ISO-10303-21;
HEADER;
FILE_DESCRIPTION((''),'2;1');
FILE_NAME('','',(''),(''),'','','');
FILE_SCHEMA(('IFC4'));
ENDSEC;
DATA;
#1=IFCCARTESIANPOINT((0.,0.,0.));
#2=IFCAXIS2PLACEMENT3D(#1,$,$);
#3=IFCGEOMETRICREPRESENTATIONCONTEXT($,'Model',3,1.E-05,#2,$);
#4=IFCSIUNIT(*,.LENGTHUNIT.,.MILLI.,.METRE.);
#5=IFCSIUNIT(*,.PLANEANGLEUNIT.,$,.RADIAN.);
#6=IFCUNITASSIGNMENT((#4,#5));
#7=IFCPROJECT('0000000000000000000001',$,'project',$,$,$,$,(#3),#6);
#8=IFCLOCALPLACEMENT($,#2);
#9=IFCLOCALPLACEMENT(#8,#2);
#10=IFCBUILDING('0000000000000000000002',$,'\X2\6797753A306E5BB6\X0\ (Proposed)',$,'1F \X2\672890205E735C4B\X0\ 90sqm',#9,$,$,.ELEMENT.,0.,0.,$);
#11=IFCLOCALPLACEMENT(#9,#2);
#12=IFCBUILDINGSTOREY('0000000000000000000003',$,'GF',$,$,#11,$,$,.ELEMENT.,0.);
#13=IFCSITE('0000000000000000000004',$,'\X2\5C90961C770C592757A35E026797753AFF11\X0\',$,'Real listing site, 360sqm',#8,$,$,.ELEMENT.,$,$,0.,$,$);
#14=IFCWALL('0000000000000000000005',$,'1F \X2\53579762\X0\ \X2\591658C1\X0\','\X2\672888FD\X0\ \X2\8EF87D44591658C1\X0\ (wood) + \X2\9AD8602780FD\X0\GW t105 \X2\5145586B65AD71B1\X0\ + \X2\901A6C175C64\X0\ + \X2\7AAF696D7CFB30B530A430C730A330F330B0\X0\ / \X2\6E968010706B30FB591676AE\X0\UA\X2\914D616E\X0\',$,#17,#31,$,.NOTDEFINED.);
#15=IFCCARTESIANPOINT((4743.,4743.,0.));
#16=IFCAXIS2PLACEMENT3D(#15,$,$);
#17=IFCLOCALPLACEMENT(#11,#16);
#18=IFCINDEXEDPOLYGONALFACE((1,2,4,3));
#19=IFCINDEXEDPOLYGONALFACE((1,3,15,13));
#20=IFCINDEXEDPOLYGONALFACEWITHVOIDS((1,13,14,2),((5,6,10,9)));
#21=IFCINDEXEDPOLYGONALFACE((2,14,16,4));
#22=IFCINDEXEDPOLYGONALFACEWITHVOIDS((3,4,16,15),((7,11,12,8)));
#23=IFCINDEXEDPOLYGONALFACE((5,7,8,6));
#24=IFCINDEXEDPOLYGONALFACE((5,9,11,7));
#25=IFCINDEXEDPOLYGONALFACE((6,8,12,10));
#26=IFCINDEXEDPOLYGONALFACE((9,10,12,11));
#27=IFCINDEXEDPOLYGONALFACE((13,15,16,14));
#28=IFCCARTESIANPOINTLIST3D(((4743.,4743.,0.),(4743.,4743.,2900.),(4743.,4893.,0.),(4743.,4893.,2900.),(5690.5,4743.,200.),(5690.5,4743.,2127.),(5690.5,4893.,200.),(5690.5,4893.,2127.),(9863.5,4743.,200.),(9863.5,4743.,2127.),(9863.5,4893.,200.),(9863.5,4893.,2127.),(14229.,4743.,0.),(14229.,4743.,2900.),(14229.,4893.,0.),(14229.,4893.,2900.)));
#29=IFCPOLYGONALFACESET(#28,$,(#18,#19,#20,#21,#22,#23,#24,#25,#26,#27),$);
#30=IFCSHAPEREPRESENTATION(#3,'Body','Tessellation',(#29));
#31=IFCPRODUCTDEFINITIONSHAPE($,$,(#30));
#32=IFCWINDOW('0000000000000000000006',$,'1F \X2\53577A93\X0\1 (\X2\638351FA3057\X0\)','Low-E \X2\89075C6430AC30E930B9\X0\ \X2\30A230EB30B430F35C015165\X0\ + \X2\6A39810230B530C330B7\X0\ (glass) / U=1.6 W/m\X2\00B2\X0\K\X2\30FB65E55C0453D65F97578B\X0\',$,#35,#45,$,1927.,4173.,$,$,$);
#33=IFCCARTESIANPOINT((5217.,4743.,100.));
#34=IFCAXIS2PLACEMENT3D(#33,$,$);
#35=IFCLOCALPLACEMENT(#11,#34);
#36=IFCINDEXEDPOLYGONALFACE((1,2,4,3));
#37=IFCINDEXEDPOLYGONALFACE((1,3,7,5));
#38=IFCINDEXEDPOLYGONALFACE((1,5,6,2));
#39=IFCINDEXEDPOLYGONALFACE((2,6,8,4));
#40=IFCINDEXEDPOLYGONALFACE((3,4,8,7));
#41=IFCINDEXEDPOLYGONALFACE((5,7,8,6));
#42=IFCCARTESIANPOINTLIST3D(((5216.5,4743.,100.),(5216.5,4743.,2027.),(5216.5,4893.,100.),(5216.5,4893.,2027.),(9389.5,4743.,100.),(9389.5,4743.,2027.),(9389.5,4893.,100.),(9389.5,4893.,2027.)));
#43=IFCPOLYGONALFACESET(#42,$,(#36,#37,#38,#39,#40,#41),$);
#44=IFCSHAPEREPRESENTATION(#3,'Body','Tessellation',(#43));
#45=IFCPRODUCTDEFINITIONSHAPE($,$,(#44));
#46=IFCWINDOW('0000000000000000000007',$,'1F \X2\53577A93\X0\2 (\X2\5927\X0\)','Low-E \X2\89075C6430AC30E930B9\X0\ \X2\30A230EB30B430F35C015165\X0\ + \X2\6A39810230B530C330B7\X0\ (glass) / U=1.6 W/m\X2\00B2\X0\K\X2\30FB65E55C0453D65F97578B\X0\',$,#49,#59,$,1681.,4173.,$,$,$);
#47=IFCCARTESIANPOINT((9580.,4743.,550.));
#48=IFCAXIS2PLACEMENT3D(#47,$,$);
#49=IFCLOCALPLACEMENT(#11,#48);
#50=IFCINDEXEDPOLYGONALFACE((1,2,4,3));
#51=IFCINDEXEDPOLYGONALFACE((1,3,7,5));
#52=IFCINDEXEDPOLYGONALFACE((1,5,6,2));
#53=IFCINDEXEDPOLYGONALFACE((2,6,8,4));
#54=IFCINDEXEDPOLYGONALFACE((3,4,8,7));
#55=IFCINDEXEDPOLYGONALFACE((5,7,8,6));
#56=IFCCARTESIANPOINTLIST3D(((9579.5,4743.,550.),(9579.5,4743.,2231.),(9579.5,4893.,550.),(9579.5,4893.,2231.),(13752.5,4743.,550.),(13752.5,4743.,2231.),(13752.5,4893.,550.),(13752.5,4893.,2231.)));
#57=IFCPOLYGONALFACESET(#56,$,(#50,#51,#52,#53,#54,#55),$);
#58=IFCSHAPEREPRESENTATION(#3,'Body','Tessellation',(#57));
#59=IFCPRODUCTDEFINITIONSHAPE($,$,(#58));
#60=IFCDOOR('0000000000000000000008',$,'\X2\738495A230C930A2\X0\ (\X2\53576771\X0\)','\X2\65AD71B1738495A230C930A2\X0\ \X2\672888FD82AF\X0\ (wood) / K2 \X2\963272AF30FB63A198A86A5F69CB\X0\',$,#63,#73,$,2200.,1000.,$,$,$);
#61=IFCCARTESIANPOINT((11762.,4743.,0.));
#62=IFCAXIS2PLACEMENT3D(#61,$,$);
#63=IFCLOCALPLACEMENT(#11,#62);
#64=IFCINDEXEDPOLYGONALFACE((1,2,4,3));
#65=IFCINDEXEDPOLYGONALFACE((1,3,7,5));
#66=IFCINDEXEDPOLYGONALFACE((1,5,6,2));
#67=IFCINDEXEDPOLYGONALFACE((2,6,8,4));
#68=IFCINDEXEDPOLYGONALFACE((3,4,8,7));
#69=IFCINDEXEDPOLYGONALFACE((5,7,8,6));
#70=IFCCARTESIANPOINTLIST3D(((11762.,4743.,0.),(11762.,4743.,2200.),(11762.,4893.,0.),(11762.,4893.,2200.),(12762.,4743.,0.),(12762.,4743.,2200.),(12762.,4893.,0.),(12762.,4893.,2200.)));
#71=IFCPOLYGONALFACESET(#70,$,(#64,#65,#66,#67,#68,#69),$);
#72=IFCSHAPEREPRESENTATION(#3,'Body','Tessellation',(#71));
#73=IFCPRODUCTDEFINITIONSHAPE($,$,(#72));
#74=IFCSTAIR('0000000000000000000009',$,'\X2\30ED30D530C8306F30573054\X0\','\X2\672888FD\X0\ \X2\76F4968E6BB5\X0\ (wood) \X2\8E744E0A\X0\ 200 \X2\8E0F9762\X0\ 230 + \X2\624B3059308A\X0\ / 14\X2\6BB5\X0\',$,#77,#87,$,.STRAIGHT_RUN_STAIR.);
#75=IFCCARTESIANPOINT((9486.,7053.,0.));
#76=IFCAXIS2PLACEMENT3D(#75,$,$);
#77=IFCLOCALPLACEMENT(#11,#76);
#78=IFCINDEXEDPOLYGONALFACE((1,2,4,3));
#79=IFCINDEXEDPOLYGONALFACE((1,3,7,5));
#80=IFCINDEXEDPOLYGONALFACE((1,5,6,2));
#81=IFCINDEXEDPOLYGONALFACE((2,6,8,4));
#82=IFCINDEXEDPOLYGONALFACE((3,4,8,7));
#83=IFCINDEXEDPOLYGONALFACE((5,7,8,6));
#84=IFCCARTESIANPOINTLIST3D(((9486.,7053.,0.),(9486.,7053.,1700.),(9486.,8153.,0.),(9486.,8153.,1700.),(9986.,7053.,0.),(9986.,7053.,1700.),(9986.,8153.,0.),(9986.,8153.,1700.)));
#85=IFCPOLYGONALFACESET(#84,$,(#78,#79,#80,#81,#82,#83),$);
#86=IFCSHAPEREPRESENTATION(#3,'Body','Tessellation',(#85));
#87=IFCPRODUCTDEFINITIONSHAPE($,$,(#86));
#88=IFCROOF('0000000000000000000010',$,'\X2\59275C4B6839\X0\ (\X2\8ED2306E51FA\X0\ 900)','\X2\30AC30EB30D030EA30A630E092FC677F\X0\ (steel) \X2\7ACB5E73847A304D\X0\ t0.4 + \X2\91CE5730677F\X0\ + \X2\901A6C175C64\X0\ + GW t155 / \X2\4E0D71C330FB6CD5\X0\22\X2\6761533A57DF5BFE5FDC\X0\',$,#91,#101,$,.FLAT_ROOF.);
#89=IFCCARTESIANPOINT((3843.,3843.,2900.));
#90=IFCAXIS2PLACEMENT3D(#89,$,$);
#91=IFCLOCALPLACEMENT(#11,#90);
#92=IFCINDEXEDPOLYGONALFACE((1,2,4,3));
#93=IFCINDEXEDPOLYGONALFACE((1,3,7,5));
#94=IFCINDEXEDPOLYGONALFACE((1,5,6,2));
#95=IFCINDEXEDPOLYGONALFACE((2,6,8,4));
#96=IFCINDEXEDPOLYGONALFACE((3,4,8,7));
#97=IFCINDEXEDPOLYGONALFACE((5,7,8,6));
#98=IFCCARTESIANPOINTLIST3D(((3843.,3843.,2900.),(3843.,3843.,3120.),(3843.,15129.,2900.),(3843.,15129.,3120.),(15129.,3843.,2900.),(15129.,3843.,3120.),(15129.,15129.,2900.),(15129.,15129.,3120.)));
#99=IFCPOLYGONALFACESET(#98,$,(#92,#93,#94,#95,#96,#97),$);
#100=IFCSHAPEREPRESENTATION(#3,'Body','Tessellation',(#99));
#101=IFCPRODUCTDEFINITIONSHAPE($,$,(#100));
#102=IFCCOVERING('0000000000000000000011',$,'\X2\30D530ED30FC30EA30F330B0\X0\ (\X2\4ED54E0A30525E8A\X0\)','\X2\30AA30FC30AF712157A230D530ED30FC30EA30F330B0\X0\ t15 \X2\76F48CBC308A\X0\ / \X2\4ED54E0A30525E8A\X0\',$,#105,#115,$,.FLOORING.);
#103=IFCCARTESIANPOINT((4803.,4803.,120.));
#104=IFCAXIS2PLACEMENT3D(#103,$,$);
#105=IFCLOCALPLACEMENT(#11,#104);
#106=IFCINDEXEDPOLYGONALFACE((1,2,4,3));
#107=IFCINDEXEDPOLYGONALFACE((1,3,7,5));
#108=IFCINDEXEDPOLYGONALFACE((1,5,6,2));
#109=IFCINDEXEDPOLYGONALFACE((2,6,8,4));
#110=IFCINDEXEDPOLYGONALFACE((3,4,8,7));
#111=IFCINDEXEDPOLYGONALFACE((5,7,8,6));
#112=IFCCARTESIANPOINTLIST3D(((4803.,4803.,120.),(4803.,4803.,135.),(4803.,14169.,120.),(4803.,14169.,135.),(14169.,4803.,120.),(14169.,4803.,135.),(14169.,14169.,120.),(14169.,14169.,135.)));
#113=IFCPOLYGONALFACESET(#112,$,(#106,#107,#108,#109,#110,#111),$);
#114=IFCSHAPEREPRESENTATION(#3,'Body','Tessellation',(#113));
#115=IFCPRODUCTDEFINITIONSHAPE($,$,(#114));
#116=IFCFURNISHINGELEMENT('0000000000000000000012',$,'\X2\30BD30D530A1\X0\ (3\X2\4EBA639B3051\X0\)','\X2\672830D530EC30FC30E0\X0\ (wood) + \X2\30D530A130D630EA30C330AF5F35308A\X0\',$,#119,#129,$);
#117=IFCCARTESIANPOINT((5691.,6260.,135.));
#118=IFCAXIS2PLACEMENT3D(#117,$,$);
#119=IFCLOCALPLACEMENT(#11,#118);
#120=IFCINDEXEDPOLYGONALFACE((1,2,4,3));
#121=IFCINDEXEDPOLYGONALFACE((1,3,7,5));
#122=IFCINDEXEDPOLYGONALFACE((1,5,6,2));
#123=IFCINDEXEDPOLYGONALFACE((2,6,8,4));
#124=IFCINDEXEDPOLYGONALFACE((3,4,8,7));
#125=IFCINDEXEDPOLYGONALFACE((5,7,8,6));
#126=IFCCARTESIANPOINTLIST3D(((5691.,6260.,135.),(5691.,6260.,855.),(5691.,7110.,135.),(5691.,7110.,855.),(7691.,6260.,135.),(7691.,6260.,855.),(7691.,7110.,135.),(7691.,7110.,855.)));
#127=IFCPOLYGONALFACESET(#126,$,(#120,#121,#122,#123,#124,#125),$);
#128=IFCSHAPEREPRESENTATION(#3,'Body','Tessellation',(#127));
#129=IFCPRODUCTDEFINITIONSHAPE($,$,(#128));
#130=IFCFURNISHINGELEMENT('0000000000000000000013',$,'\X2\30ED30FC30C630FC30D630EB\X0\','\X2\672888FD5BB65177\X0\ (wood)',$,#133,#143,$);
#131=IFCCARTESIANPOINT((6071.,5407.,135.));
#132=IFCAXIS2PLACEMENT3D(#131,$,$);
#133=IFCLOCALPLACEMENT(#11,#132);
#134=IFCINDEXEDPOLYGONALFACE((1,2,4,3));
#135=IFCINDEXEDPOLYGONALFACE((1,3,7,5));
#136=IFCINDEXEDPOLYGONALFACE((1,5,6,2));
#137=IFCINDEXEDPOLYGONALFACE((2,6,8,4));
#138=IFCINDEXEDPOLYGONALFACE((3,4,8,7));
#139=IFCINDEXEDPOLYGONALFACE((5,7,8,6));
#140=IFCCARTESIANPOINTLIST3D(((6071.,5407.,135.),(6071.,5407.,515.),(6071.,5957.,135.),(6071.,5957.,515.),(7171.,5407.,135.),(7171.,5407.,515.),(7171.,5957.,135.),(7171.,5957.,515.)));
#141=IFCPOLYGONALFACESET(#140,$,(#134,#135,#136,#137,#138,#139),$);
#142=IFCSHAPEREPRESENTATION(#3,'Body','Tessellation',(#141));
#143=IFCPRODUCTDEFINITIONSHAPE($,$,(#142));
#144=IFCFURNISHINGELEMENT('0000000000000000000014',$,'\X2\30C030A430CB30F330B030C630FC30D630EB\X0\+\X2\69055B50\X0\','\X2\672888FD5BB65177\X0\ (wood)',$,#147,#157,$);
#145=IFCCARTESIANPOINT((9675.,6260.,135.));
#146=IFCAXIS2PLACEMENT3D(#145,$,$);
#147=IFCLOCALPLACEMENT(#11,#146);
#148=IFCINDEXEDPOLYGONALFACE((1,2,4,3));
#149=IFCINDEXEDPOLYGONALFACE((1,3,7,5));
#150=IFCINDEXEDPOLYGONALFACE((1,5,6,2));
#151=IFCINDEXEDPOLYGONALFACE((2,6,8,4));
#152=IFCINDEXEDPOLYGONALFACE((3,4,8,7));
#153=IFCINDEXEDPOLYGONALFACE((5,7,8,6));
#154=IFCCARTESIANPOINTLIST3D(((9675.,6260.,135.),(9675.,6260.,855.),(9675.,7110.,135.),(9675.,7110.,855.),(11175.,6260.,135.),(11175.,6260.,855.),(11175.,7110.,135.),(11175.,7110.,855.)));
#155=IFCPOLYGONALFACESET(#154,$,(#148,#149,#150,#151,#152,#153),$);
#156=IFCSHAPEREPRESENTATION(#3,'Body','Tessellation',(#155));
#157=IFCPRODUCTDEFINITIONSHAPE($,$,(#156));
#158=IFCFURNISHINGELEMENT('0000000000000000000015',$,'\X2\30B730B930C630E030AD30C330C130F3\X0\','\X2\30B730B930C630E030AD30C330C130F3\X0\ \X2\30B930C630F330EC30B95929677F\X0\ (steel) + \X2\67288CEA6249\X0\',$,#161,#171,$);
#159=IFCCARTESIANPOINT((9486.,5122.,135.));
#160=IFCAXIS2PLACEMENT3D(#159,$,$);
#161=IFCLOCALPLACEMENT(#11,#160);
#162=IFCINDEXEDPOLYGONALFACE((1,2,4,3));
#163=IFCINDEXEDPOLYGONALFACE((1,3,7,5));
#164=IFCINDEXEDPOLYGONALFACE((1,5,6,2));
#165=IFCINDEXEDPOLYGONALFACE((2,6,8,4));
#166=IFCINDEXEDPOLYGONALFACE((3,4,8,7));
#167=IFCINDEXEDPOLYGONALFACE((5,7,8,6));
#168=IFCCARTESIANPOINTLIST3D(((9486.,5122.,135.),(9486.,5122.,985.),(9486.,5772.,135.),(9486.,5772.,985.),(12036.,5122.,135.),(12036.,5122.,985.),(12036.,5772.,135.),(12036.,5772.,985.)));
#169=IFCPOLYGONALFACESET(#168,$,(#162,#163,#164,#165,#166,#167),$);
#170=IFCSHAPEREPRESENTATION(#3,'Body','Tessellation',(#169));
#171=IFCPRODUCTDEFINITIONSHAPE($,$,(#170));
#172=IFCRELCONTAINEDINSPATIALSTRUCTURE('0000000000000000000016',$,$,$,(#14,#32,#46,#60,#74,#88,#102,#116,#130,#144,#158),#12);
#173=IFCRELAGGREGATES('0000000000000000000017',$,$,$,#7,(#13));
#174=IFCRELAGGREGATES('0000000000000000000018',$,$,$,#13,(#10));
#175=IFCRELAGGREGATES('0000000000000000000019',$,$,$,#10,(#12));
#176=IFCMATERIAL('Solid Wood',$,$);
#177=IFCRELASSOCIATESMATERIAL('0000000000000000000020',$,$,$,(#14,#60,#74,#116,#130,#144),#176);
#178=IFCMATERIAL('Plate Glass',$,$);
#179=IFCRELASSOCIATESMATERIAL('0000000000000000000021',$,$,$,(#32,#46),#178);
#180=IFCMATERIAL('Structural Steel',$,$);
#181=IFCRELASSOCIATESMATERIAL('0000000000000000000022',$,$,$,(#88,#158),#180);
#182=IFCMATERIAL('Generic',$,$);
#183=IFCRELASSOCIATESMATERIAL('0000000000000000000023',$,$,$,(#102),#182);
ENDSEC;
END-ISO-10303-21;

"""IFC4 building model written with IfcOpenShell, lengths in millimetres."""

from ifc_helpers import new_model, si_unit, frame, frame_2d, origin, place, context, project, spatial, rectangle, extrude, material, element, fill, save


model = new_model("IFC4")

# Units and contexts
model_context = context("Model", 3, precision=1e-05, world=origin())
ifc_project = project(units=[si_unit("LENGTHUNIT", "METRE", prefix="MILLI"), si_unit("PLANEANGLEUNIT", "RADIAN")], contexts=[model_context])

# Site, building, storey
site_placement = place(None, origin())
site = spatial("IfcSite", under=ifc_project, at=site_placement, Name="岐阜県大垣市林町１", ObjectType="Real listing site, 360sqm", CompositionType="ELEMENT", RefElevation=0.0)
building_placement = place(site_placement, origin())
building = spatial("IfcBuilding", under=site, at=building_placement, Name="林町の家 (Proposed)", ObjectType="1F 木造平屋 90sqm", CompositionType="ELEMENT", ElevationOfRefHeight=0.0, ElevationOfTerrain=0.0)
storey_placement = place(building_placement, origin())
storey = spatial("IfcBuildingStorey", under=building, at=storey_placement, Name="GF", CompositionType="ELEMENT", Elevation=0.0)

# Shared definitions
ifc_material_1 = material(Name="Solid Wood")

# Wall, openings, windows, door
wall_1_placement = place(storey_placement, frame((4743.0, 4743.0, 0.0)))
wall_1 = element("IfcWall", 1, at=wall_1_placement, inside=storey, material=ifc_material_1, Name="1F 南面 外壁", Description="木製 軸組外壁 (wood) + 高性能GW t105 充填断熱 + 通気層 + 窯業系サイディング / 準耐火・外皮UA配慮", PredefinedType="NOTDEFINED", context=model_context, shape_type="SweptSolid", body=[
    extrude(rectangle(XDim=9486.0, YDim=150.0, at=frame_2d((4743.0, 75.0))), frame((4743.0, 4743.0, 0.0)), (0.0, 0.0, 1.0), 2900.0),
])
opening_1_placement = place(storey_placement, frame((5217.0, 4743.0, 100.0)))
opening_1 = element("IfcOpeningElement", 2, at=opening_1_placement, cuts=wall_1, PredefinedType="NOTDEFINED", context=model_context, shape_type="SweptSolid", body=[
    extrude(rectangle(XDim=4173.0, YDim=150.0, at=frame_2d((2086.0, 75.0))), frame((5217.0, 4743.0, 100.0)), (0.0, 0.0, 1.0), 1927.0),
])
opening_2_placement = place(storey_placement, frame((9580.0, 4743.0, 550.0)))
opening_2 = element("IfcOpeningElement", 3, at=opening_2_placement, cuts=wall_1, PredefinedType="NOTDEFINED", context=model_context, shape_type="SweptSolid", body=[
    extrude(rectangle(XDim=4173.0, YDim=150.0, at=frame_2d((2086.0, 75.0))), frame((9580.0, 4743.0, 550.0)), (0.0, 0.0, 1.0), 1681.0),
])
opening_3_placement = place(storey_placement, frame((11762.0, 4743.0, 0.0)))
opening_3 = element("IfcOpeningElement", 4, at=opening_3_placement, cuts=wall_1, PredefinedType="NOTDEFINED", context=model_context, shape_type="SweptSolid", body=[
    extrude(rectangle(XDim=1000.0, YDim=150.0, at=frame_2d((500.0, 75.0))), frame((11762.0, 4743.0, 0.0)), (0.0, 0.0, 1.0), 2200.0),
])
ifc_material_2 = material(Name="Plate Glass")
window_1_placement = place(storey_placement, frame((5217.0, 4743.0, 100.0)))
window_1 = element("IfcWindow", 5, at=window_1_placement, inside=storey, material=ifc_material_2, Name="1F 南窓1 (掃出し)", Description="Low-E 複層ガラス アルゴン封入 + 樹脂サッシ (glass) / U=1.6 W/m²K・日射取得型", OverallHeight=1927.0, OverallWidth=4173.0, context=model_context, shape_type="SweptSolid", body=[
    extrude(rectangle(XDim=4173.0, YDim=150.0, at=frame_2d((2086.0, 75.0))), frame((5217.0, 4743.0, 100.0)), (0.0, 0.0, 1.0), 1927.0),
])
fill(opening_1, window_1)
window_2_placement = place(storey_placement, frame((9580.0, 4743.0, 550.0)))
window_2 = element("IfcWindow", 6, at=window_2_placement, inside=storey, material=ifc_material_2, Name="1F 南窓2 (大)", Description="Low-E 複層ガラス アルゴン封入 + 樹脂サッシ (glass) / U=1.6 W/m²K・日射取得型", OverallHeight=1681.0, OverallWidth=4173.0, context=model_context, shape_type="SweptSolid", body=[
    extrude(rectangle(XDim=4173.0, YDim=150.0, at=frame_2d((2086.0, 75.0))), frame((9580.0, 4743.0, 550.0)), (0.0, 0.0, 1.0), 1681.0),
])
fill(opening_2, window_2)
door_placement = place(storey_placement, frame((11762.0, 4743.0, 0.0)))
door = element("IfcDoor", 7, at=door_placement, inside=storey, material=ifc_material_1, Name="玄関ドア (南東)", Description="断熱玄関ドア 木製芯 (wood) / K2 防犯・採風機構", OverallHeight=2200.0, OverallWidth=1000.0, context=model_context, shape_type="SweptSolid", body=[
    extrude(rectangle(XDim=1000.0, YDim=150.0, at=frame_2d((500.0, 75.0))), frame((11762.0, 4743.0, 0.0)), (0.0, 0.0, 1.0), 2200.0),
])
fill(opening_3, door)

# Stair
stair_placement = place(storey_placement, frame((9486.0, 7053.0, 0.0)))
element("IfcStair", 8, at=stair_placement, inside=storey, material=ifc_material_1, Name="ロフトはしご", Description="木製 直階段 (wood) 蹴上 200 踏面 230 + 手すり / 14段", PredefinedType="STRAIGHT_RUN_STAIR", context=model_context, shape_type="SweptSolid", body=[
    extrude(rectangle(XDim=500.0, YDim=1100.0, at=frame_2d((250.0, 550.0))), frame((9486.0, 7053.0, 0.0)), (0.0, 0.0, 1.0), 1700.0),
])

# Roof
ifc_material_3 = material(Name="Structural Steel")
roof_placement = place(storey_placement, frame((3843.0, 3843.0, 2900.0)))
element("IfcRoof", 9, at=roof_placement, inside=storey, material=ifc_material_3, Name="大屋根 (軒の出 900)", Description="ガルバリウム鋼板 (steel) 立平葺き t0.4 + 野地板 + 通気層 + GW t155 / 不燃・法22条区域対応", PredefinedType="FLAT_ROOF", context=model_context, shape_type="SweptSolid", body=[
    extrude(rectangle(XDim=11286.0, YDim=11286.0, at=frame_2d((5643.0, 5643.0))), frame((3843.0, 3843.0, 2900.0)), (0.0, 0.0, 1.0), 220.0),
])

# Covering
ifc_material_4 = material(Name="Generic")
covering_placement = place(storey_placement, frame((4803.0, 4803.0, 120.0)))
element("IfcCovering", 10, at=covering_placement, inside=storey, material=ifc_material_4, Name="フローリング (仕上げ床)", Description="オーク無垢フローリング t15 直貼り / 仕上げ床", PredefinedType="FLOORING", context=model_context, shape_type="SweptSolid", body=[
    extrude(rectangle(XDim=9366.0, YDim=9366.0, at=frame_2d((4683.0, 4683.0))), frame((4803.0, 4803.0, 120.0)), (0.0, 0.0, 1.0), 15.0),
])

# Furnishing elements
furnishing_1_placement = place(storey_placement, frame((5691.0, 6260.0, 135.0)))
element("IfcFurnishingElement", 11, at=furnishing_1_placement, inside=storey, material=ifc_material_1, Name="ソファ (3人掛け)", Description="木フレーム (wood) + ファブリック張り", context=model_context, shape_type="SweptSolid", body=[
    extrude(rectangle(XDim=2000.0, YDim=850.0, at=frame_2d((1000.0, 425.0))), frame((5691.0, 6260.0, 135.0)), (0.0, 0.0, 1.0), 720.0),
])
furnishing_2_placement = place(storey_placement, frame((6071.0, 5407.0, 135.0)))
element("IfcFurnishingElement", 12, at=furnishing_2_placement, inside=storey, material=ifc_material_1, Name="ローテーブル", Description="木製家具 (wood)", context=model_context, shape_type="SweptSolid", body=[
    extrude(rectangle(XDim=1100.0, YDim=550.0, at=frame_2d((550.0, 275.0))), frame((6071.0, 5407.0, 135.0)), (0.0, 0.0, 1.0), 380.0),
])
furnishing_3_placement = place(storey_placement, frame((9675.0, 6260.0, 135.0)))
element("IfcFurnishingElement", 13, at=furnishing_3_placement, inside=storey, material=ifc_material_1, Name="ダイニングテーブル+椅子", Description="木製家具 (wood)", context=model_context, shape_type="SweptSolid", body=[
    extrude(rectangle(XDim=1500.0, YDim=850.0, at=frame_2d((750.0, 425.0))), frame((9675.0, 6260.0, 135.0)), (0.0, 0.0, 1.0), 720.0),
])
furnishing_4_placement = place(storey_placement, frame((9486.0, 5122.0, 135.0)))
element("IfcFurnishingElement", 14, at=furnishing_4_placement, inside=storey, material=ifc_material_3, Name="システムキッチン", Description="システムキッチン ステンレス天板 (steel) + 木質扉", context=model_context, shape_type="SweptSolid", body=[
    extrude(rectangle(XDim=2550.0, YDim=650.0, at=frame_2d((1275.0, 325.0))), frame((9486.0, 5122.0, 135.0)), (0.0, 0.0, 1.0), 850.0),
])

save(model, "model.ifc")
